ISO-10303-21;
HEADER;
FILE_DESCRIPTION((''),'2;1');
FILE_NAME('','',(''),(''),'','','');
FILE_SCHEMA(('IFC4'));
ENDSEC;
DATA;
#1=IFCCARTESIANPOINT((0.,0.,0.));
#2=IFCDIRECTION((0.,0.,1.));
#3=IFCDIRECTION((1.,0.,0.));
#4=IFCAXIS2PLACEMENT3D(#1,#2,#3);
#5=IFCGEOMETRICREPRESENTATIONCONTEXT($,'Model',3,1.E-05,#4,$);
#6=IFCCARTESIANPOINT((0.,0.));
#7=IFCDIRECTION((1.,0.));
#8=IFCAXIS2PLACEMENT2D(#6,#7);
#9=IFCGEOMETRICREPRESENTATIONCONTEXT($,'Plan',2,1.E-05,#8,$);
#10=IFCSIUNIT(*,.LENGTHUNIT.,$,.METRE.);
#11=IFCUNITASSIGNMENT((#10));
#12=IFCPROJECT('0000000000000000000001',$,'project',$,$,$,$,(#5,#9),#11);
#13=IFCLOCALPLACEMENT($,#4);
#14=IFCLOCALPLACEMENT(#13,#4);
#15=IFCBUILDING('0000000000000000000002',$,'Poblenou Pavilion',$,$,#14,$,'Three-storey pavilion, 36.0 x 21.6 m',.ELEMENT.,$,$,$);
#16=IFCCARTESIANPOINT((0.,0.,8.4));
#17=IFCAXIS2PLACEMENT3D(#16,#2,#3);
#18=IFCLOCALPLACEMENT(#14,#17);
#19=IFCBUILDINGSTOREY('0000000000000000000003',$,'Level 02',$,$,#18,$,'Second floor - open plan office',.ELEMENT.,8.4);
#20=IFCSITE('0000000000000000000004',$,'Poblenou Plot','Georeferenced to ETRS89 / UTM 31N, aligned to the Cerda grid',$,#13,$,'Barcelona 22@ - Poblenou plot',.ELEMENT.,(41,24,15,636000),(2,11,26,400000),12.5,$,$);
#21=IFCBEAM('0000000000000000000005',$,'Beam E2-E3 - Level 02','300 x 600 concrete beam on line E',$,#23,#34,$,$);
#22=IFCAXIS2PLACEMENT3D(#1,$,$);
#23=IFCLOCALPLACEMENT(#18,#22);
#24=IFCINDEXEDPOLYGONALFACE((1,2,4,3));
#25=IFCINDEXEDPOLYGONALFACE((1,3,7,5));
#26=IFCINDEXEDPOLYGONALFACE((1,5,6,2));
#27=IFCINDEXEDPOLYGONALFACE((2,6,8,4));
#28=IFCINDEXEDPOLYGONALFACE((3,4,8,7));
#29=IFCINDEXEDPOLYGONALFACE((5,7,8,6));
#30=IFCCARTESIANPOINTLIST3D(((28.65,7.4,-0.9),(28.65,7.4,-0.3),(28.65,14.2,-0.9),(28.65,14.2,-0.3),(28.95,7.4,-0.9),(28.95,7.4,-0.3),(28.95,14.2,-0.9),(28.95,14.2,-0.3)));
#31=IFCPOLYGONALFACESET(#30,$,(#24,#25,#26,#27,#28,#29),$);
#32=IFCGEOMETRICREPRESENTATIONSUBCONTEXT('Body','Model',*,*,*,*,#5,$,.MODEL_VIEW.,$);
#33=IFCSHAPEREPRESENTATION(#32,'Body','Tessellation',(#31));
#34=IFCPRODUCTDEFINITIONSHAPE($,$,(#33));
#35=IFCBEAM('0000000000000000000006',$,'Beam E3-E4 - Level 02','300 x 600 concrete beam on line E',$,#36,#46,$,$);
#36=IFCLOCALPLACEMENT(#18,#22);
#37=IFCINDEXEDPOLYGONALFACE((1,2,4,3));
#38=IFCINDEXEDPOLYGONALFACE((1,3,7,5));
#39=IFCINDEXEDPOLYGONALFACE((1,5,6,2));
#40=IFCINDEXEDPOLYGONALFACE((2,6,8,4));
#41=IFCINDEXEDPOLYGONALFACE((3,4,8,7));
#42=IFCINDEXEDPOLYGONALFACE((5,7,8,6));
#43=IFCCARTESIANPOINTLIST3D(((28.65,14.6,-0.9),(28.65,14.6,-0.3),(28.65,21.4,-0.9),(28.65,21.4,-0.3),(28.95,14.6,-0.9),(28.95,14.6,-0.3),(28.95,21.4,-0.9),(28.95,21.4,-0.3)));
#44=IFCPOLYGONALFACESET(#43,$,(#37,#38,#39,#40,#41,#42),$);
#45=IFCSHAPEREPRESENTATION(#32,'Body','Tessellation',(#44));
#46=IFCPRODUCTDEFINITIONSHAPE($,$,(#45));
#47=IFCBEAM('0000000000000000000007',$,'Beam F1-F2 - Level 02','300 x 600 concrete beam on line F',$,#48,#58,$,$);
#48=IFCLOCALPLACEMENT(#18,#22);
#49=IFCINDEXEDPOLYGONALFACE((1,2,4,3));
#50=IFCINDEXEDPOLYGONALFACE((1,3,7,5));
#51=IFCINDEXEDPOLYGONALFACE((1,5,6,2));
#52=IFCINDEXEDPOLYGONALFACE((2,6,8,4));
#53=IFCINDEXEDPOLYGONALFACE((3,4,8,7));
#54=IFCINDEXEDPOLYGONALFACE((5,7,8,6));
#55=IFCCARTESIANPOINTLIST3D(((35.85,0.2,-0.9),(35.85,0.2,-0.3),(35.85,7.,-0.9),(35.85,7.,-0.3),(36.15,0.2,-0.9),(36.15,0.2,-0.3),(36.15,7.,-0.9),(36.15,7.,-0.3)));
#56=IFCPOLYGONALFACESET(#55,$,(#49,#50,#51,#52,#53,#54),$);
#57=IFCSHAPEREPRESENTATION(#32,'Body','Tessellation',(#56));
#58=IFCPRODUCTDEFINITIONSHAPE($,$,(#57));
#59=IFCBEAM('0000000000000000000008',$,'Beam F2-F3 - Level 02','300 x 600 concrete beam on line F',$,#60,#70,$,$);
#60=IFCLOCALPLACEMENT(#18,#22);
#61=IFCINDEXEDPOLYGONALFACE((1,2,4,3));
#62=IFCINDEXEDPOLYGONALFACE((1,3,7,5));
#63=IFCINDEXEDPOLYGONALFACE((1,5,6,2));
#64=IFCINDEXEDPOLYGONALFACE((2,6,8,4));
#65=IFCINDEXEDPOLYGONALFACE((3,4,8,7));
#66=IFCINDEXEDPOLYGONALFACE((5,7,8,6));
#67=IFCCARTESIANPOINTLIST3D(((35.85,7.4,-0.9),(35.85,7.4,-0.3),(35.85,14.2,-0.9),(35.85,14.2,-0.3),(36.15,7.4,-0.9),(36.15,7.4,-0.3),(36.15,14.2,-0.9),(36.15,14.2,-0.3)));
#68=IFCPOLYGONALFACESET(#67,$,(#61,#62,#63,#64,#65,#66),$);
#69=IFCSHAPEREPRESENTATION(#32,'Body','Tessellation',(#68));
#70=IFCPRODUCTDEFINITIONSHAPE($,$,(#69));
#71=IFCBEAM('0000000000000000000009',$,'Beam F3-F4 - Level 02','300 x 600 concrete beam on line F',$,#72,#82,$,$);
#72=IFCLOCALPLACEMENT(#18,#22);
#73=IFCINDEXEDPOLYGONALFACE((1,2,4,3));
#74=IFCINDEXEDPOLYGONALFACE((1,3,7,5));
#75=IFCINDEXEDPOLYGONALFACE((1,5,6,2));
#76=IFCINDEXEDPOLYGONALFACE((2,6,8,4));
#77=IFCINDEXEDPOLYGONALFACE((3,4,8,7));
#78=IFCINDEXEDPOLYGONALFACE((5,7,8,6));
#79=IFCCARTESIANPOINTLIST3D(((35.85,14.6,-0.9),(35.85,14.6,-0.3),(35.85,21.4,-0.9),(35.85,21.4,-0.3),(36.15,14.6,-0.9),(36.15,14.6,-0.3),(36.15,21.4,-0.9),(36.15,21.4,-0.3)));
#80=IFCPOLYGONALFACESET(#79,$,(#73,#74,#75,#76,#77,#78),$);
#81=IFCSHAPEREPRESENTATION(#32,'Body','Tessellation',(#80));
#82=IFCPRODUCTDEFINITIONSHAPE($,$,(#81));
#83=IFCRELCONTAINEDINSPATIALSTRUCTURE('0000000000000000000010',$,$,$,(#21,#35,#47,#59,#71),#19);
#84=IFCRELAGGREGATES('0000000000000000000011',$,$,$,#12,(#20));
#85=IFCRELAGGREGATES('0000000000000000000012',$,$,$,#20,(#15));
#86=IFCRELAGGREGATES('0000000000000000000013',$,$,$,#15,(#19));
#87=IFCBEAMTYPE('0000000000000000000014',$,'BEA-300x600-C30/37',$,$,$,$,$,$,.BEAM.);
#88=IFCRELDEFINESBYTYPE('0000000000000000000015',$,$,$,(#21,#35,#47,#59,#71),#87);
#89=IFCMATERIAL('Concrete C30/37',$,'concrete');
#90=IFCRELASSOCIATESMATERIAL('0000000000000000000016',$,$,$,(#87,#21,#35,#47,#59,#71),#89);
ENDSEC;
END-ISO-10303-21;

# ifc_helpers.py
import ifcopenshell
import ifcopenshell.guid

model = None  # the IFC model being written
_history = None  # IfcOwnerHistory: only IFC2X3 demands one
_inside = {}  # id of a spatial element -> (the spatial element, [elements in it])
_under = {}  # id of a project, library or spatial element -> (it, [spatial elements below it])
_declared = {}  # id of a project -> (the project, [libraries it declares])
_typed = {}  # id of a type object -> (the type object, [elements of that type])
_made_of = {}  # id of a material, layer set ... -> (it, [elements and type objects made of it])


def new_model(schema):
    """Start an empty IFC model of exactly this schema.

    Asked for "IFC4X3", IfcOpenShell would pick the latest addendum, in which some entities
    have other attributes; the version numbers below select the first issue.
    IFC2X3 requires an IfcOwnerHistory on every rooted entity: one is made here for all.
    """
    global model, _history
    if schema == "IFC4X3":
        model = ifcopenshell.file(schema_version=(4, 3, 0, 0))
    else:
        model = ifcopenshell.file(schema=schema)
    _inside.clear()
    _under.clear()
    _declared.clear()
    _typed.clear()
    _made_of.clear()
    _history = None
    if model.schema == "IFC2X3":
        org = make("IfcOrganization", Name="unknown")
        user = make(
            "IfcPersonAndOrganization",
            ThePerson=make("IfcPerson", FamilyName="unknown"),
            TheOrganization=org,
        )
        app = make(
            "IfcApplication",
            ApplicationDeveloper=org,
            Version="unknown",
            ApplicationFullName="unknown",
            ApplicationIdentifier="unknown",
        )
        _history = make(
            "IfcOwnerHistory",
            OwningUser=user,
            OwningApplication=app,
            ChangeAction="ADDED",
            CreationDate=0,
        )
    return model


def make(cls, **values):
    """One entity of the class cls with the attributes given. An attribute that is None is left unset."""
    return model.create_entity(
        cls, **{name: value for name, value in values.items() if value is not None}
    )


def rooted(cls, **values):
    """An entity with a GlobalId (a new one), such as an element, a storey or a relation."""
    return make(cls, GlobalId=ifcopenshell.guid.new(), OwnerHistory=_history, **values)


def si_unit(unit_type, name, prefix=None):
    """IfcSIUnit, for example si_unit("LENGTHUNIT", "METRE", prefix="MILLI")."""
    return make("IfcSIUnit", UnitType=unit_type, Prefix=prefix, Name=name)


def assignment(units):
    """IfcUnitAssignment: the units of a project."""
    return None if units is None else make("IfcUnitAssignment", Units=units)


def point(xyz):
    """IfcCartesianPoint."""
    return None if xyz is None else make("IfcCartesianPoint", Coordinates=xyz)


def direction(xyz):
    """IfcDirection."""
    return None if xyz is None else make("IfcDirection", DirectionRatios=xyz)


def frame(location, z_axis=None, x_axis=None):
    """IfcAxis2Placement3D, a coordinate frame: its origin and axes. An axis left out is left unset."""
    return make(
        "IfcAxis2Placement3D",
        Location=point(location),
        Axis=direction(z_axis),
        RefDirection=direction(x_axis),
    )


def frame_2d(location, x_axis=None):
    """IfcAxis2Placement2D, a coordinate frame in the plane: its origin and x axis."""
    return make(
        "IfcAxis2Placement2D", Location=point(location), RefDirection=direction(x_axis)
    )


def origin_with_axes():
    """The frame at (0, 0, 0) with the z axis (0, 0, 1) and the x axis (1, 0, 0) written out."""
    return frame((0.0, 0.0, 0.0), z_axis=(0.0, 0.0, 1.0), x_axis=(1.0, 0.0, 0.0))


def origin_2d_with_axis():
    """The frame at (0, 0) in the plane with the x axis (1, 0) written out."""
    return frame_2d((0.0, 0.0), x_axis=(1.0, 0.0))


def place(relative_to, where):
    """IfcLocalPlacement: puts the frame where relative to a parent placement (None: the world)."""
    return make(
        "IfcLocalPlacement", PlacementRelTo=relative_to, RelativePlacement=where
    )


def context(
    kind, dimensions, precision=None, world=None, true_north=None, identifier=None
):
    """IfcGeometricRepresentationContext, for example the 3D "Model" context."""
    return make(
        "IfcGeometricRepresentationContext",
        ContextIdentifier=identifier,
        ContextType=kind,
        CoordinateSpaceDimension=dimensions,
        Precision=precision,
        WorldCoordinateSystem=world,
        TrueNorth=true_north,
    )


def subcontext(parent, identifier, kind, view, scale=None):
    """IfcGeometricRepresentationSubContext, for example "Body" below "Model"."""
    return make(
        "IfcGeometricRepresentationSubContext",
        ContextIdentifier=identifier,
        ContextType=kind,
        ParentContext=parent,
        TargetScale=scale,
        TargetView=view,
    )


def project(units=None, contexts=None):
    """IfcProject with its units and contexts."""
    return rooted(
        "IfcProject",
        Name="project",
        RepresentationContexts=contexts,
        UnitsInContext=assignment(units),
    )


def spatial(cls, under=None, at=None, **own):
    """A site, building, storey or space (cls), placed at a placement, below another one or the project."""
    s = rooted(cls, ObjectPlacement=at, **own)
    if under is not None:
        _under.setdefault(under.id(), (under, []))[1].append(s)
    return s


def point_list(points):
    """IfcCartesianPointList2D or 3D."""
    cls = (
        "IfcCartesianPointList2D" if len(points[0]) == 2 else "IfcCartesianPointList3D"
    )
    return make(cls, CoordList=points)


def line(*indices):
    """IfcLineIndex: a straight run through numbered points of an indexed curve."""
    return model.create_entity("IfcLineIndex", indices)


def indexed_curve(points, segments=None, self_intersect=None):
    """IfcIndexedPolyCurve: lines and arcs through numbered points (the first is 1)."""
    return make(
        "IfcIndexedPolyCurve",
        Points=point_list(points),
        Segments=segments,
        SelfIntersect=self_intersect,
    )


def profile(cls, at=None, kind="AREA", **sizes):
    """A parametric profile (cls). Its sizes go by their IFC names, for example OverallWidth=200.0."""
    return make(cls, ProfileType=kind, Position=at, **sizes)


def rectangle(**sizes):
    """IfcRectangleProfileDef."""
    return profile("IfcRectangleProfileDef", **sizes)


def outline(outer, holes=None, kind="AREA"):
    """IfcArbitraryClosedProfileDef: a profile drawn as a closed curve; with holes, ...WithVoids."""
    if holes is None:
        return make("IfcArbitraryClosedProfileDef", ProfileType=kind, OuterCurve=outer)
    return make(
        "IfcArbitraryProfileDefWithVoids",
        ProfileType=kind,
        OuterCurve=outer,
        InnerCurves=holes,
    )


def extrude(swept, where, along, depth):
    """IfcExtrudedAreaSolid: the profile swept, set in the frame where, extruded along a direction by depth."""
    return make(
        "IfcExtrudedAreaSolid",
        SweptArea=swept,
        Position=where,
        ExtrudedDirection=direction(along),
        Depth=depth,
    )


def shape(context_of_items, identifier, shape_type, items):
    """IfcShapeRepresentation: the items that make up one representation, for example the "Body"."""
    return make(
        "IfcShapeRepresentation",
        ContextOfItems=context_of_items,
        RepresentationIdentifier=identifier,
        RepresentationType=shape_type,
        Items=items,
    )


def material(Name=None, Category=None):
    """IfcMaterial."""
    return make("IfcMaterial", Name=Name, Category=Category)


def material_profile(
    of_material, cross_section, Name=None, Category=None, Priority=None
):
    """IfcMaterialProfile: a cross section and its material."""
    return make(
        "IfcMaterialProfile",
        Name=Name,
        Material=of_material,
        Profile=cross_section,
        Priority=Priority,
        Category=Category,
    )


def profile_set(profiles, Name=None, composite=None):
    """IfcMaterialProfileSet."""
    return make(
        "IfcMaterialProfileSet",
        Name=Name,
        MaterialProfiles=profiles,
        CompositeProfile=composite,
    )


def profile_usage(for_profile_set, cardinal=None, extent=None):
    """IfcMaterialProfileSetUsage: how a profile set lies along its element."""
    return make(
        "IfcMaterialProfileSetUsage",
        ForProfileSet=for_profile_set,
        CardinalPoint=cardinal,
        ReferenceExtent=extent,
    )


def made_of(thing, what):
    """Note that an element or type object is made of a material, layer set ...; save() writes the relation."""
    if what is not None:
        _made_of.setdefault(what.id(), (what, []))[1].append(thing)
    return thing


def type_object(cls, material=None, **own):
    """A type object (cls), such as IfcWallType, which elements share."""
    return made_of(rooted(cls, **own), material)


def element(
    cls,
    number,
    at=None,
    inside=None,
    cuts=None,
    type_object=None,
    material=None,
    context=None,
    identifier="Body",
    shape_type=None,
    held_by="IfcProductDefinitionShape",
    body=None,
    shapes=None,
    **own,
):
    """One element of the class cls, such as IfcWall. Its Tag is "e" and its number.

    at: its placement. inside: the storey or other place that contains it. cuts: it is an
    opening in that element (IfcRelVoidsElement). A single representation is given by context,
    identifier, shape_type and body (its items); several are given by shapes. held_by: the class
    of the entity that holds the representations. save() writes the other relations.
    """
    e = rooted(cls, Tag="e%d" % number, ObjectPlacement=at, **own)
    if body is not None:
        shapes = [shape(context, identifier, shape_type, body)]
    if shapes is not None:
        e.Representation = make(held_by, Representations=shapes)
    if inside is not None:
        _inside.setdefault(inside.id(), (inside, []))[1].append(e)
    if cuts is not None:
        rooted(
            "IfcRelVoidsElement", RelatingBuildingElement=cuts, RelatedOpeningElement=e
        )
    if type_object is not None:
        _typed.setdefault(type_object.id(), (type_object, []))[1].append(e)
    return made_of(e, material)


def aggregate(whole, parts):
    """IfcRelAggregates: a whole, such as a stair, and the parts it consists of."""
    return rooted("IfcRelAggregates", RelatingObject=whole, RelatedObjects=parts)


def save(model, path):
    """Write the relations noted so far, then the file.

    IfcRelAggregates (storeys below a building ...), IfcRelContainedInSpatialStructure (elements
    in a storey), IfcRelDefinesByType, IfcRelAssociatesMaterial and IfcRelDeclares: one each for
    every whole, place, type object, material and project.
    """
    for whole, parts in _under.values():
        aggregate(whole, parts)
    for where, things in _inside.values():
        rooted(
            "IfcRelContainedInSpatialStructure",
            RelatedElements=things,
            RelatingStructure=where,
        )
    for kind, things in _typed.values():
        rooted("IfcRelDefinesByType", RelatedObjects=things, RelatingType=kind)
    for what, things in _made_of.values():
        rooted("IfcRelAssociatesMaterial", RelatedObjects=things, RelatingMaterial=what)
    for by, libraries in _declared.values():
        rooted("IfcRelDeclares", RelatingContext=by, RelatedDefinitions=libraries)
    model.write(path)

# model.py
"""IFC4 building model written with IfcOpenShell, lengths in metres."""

from ifc_helpers import new_model, si_unit, frame, origin_with_axes, origin_2d_with_axis, place, context, subcontext, project, spatial, line, indexed_curve, rectangle, outline, extrude, material, material_profile, profile_set, profile_usage, type_object, element, save


model = new_model("IFC4")

# Units and contexts
model_context = context("Model", 3, precision=1e-05, world=origin_with_axes())
plan_context = context("Plan", 2, precision=1e-05, world=origin_2d_with_axis())
body_context = subcontext(model_context, "Body", "Model", "MODEL_VIEW")
ifc_project = project(units=[si_unit("LENGTHUNIT", "METRE")], contexts=[model_context, plan_context])

# Site, building, storey
site_placement = place(None, origin_with_axes())
site = spatial("IfcSite", under=ifc_project, at=site_placement, Name="Poblenou Plot", Description="Georeferenced to ETRS89 / UTM 31N, aligned to the Cerda grid", LongName="Barcelona 22@ - Poblenou plot", CompositionType="ELEMENT", RefLatitude=(41, 24, 15, 636000), RefLongitude=(2, 11, 26, 400000), RefElevation=12.5)
building_placement = place(site_placement, origin_with_axes())
building = spatial("IfcBuilding", under=site, at=building_placement, Name="Poblenou Pavilion", LongName="Three-storey pavilion, 36.0 x 21.6 m", CompositionType="ELEMENT")
storey_placement = place(building_placement, frame((0.0, 0.0, 8.4), z_axis=(0.0, 0.0, 1.0), x_axis=(1.0, 0.0, 0.0)))
storey = spatial("IfcBuildingStorey", under=building, at=storey_placement, Name="Level 02", LongName="Second floor - open plan office", CompositionType="ELEMENT", Elevation=8.4)

# Shared definitions
ifc_material = material(Name="Concrete C30/37", Category="concrete")

# Beams
ifc_material_profile_1 = material_profile(ifc_material, rectangle(XDim=0.3, YDim=0.6))
ifc_profile_set_1 = profile_set([ifc_material_profile_1], Name="BEA-300x600-C30/37")
beam_type = type_object("IfcBeamType", Name="BEA-300x600-C30/37", PredefinedType="BEAM", material=ifc_profile_set_1)
ifc_profile_usage_1 = profile_usage(ifc_profile_set_1)
beam_1_placement = place(storey_placement, frame((28.65, 7.4, -0.9), z_axis=(0.0, 1.0, 0.0), x_axis=(0.0, 0.0, 1.0)))
element("IfcBeam", 1, at=beam_1_placement, inside=storey, type_object=beam_type, material=ifc_profile_usage_1, Name="Beam E2-E3 - Level 02", Description="300 x 600 concrete beam on line E", context=body_context, shape_type="SweptSolid", body=[
    extrude(outline(indexed_curve([(0.0, 0.0), (0.6, 0.0), (0.6, 0.3), (0.0, 0.3)], segments=[line(1, 2, 3, 4, 1)])), origin_with_axes(), (0.0, 0.0, 1.0), 6.8),
])
ifc_profile_usage_2 = profile_usage(ifc_profile_set_1)
beam_2_placement = place(storey_placement, frame((28.65, 14.6, -0.9), z_axis=(0.0, 1.0, 0.0), x_axis=(0.0, 0.0, 1.0)))
element("IfcBeam", 2, at=beam_2_placement, inside=storey, type_object=beam_type, material=ifc_profile_usage_2, Name="Beam E3-E4 - Level 02", Description="300 x 600 concrete beam on line E", context=body_context, shape_type="SweptSolid", body=[
    extrude(outline(indexed_curve([(0.0, 0.0), (0.6, 0.0), (0.6, 0.3), (0.0, 0.3)], segments=[line(1, 2, 3, 4, 1)])), origin_with_axes(), (0.0, 0.0, 1.0), 6.8),
])
ifc_profile_usage_3 = profile_usage(ifc_profile_set_1)
beam_3_placement = place(storey_placement, frame((35.85, 0.2, -0.9), z_axis=(0.0, 1.0, 0.0), x_axis=(0.0, 0.0, 1.0)))
element("IfcBeam", 3, at=beam_3_placement, inside=storey, type_object=beam_type, material=ifc_profile_usage_3, Name="Beam F1-F2 - Level 02", Description="300 x 600 concrete beam on line F", context=body_context, shape_type="SweptSolid", body=[
    extrude(outline(indexed_curve([(0.0, 0.0), (0.6, 0.0), (0.6, 0.3), (0.0, 0.3)], segments=[line(1, 2, 3, 4, 1)])), origin_with_axes(), (0.0, 0.0, 1.0), 6.8),
])
ifc_profile_usage_4 = profile_usage(ifc_profile_set_1)
beam_4_placement = place(storey_placement, frame((35.85, 7.4, -0.9), z_axis=(0.0, 1.0, 0.0), x_axis=(0.0, 0.0, 1.0)))
element("IfcBeam", 4, at=beam_4_placement, inside=storey, type_object=beam_type, material=ifc_profile_usage_4, Name="Beam F2-F3 - Level 02", Description="300 x 600 concrete beam on line F", context=body_context, shape_type="SweptSolid", body=[
    extrude(outline(indexed_curve([(0.0, 0.0), (0.6, 0.0), (0.6, 0.3), (0.0, 0.3)], segments=[line(1, 2, 3, 4, 1)])), origin_with_axes(), (0.0, 0.0, 1.0), 6.8),
])
ifc_profile_usage_5 = profile_usage(ifc_profile_set_1)
beam_5_placement = place(storey_placement, frame((35.85, 14.6, -0.9), z_axis=(0.0, 1.0, 0.0), x_axis=(0.0, 0.0, 1.0)))
element("IfcBeam", 5, at=beam_5_placement, inside=storey, type_object=beam_type, material=ifc_profile_usage_5, Name="Beam F3-F4 - Level 02", Description="300 x 600 concrete beam on line F", context=body_context, shape_type="SweptSolid", body=[
    extrude(outline(indexed_curve([(0.0, 0.0), (0.6, 0.0), (0.6, 0.3), (0.0, 0.3)], segments=[line(1, 2, 3, 4, 1)])), origin_with_axes(), (0.0, 0.0, 1.0), 6.8),
])

save(model, "model.ifc")
